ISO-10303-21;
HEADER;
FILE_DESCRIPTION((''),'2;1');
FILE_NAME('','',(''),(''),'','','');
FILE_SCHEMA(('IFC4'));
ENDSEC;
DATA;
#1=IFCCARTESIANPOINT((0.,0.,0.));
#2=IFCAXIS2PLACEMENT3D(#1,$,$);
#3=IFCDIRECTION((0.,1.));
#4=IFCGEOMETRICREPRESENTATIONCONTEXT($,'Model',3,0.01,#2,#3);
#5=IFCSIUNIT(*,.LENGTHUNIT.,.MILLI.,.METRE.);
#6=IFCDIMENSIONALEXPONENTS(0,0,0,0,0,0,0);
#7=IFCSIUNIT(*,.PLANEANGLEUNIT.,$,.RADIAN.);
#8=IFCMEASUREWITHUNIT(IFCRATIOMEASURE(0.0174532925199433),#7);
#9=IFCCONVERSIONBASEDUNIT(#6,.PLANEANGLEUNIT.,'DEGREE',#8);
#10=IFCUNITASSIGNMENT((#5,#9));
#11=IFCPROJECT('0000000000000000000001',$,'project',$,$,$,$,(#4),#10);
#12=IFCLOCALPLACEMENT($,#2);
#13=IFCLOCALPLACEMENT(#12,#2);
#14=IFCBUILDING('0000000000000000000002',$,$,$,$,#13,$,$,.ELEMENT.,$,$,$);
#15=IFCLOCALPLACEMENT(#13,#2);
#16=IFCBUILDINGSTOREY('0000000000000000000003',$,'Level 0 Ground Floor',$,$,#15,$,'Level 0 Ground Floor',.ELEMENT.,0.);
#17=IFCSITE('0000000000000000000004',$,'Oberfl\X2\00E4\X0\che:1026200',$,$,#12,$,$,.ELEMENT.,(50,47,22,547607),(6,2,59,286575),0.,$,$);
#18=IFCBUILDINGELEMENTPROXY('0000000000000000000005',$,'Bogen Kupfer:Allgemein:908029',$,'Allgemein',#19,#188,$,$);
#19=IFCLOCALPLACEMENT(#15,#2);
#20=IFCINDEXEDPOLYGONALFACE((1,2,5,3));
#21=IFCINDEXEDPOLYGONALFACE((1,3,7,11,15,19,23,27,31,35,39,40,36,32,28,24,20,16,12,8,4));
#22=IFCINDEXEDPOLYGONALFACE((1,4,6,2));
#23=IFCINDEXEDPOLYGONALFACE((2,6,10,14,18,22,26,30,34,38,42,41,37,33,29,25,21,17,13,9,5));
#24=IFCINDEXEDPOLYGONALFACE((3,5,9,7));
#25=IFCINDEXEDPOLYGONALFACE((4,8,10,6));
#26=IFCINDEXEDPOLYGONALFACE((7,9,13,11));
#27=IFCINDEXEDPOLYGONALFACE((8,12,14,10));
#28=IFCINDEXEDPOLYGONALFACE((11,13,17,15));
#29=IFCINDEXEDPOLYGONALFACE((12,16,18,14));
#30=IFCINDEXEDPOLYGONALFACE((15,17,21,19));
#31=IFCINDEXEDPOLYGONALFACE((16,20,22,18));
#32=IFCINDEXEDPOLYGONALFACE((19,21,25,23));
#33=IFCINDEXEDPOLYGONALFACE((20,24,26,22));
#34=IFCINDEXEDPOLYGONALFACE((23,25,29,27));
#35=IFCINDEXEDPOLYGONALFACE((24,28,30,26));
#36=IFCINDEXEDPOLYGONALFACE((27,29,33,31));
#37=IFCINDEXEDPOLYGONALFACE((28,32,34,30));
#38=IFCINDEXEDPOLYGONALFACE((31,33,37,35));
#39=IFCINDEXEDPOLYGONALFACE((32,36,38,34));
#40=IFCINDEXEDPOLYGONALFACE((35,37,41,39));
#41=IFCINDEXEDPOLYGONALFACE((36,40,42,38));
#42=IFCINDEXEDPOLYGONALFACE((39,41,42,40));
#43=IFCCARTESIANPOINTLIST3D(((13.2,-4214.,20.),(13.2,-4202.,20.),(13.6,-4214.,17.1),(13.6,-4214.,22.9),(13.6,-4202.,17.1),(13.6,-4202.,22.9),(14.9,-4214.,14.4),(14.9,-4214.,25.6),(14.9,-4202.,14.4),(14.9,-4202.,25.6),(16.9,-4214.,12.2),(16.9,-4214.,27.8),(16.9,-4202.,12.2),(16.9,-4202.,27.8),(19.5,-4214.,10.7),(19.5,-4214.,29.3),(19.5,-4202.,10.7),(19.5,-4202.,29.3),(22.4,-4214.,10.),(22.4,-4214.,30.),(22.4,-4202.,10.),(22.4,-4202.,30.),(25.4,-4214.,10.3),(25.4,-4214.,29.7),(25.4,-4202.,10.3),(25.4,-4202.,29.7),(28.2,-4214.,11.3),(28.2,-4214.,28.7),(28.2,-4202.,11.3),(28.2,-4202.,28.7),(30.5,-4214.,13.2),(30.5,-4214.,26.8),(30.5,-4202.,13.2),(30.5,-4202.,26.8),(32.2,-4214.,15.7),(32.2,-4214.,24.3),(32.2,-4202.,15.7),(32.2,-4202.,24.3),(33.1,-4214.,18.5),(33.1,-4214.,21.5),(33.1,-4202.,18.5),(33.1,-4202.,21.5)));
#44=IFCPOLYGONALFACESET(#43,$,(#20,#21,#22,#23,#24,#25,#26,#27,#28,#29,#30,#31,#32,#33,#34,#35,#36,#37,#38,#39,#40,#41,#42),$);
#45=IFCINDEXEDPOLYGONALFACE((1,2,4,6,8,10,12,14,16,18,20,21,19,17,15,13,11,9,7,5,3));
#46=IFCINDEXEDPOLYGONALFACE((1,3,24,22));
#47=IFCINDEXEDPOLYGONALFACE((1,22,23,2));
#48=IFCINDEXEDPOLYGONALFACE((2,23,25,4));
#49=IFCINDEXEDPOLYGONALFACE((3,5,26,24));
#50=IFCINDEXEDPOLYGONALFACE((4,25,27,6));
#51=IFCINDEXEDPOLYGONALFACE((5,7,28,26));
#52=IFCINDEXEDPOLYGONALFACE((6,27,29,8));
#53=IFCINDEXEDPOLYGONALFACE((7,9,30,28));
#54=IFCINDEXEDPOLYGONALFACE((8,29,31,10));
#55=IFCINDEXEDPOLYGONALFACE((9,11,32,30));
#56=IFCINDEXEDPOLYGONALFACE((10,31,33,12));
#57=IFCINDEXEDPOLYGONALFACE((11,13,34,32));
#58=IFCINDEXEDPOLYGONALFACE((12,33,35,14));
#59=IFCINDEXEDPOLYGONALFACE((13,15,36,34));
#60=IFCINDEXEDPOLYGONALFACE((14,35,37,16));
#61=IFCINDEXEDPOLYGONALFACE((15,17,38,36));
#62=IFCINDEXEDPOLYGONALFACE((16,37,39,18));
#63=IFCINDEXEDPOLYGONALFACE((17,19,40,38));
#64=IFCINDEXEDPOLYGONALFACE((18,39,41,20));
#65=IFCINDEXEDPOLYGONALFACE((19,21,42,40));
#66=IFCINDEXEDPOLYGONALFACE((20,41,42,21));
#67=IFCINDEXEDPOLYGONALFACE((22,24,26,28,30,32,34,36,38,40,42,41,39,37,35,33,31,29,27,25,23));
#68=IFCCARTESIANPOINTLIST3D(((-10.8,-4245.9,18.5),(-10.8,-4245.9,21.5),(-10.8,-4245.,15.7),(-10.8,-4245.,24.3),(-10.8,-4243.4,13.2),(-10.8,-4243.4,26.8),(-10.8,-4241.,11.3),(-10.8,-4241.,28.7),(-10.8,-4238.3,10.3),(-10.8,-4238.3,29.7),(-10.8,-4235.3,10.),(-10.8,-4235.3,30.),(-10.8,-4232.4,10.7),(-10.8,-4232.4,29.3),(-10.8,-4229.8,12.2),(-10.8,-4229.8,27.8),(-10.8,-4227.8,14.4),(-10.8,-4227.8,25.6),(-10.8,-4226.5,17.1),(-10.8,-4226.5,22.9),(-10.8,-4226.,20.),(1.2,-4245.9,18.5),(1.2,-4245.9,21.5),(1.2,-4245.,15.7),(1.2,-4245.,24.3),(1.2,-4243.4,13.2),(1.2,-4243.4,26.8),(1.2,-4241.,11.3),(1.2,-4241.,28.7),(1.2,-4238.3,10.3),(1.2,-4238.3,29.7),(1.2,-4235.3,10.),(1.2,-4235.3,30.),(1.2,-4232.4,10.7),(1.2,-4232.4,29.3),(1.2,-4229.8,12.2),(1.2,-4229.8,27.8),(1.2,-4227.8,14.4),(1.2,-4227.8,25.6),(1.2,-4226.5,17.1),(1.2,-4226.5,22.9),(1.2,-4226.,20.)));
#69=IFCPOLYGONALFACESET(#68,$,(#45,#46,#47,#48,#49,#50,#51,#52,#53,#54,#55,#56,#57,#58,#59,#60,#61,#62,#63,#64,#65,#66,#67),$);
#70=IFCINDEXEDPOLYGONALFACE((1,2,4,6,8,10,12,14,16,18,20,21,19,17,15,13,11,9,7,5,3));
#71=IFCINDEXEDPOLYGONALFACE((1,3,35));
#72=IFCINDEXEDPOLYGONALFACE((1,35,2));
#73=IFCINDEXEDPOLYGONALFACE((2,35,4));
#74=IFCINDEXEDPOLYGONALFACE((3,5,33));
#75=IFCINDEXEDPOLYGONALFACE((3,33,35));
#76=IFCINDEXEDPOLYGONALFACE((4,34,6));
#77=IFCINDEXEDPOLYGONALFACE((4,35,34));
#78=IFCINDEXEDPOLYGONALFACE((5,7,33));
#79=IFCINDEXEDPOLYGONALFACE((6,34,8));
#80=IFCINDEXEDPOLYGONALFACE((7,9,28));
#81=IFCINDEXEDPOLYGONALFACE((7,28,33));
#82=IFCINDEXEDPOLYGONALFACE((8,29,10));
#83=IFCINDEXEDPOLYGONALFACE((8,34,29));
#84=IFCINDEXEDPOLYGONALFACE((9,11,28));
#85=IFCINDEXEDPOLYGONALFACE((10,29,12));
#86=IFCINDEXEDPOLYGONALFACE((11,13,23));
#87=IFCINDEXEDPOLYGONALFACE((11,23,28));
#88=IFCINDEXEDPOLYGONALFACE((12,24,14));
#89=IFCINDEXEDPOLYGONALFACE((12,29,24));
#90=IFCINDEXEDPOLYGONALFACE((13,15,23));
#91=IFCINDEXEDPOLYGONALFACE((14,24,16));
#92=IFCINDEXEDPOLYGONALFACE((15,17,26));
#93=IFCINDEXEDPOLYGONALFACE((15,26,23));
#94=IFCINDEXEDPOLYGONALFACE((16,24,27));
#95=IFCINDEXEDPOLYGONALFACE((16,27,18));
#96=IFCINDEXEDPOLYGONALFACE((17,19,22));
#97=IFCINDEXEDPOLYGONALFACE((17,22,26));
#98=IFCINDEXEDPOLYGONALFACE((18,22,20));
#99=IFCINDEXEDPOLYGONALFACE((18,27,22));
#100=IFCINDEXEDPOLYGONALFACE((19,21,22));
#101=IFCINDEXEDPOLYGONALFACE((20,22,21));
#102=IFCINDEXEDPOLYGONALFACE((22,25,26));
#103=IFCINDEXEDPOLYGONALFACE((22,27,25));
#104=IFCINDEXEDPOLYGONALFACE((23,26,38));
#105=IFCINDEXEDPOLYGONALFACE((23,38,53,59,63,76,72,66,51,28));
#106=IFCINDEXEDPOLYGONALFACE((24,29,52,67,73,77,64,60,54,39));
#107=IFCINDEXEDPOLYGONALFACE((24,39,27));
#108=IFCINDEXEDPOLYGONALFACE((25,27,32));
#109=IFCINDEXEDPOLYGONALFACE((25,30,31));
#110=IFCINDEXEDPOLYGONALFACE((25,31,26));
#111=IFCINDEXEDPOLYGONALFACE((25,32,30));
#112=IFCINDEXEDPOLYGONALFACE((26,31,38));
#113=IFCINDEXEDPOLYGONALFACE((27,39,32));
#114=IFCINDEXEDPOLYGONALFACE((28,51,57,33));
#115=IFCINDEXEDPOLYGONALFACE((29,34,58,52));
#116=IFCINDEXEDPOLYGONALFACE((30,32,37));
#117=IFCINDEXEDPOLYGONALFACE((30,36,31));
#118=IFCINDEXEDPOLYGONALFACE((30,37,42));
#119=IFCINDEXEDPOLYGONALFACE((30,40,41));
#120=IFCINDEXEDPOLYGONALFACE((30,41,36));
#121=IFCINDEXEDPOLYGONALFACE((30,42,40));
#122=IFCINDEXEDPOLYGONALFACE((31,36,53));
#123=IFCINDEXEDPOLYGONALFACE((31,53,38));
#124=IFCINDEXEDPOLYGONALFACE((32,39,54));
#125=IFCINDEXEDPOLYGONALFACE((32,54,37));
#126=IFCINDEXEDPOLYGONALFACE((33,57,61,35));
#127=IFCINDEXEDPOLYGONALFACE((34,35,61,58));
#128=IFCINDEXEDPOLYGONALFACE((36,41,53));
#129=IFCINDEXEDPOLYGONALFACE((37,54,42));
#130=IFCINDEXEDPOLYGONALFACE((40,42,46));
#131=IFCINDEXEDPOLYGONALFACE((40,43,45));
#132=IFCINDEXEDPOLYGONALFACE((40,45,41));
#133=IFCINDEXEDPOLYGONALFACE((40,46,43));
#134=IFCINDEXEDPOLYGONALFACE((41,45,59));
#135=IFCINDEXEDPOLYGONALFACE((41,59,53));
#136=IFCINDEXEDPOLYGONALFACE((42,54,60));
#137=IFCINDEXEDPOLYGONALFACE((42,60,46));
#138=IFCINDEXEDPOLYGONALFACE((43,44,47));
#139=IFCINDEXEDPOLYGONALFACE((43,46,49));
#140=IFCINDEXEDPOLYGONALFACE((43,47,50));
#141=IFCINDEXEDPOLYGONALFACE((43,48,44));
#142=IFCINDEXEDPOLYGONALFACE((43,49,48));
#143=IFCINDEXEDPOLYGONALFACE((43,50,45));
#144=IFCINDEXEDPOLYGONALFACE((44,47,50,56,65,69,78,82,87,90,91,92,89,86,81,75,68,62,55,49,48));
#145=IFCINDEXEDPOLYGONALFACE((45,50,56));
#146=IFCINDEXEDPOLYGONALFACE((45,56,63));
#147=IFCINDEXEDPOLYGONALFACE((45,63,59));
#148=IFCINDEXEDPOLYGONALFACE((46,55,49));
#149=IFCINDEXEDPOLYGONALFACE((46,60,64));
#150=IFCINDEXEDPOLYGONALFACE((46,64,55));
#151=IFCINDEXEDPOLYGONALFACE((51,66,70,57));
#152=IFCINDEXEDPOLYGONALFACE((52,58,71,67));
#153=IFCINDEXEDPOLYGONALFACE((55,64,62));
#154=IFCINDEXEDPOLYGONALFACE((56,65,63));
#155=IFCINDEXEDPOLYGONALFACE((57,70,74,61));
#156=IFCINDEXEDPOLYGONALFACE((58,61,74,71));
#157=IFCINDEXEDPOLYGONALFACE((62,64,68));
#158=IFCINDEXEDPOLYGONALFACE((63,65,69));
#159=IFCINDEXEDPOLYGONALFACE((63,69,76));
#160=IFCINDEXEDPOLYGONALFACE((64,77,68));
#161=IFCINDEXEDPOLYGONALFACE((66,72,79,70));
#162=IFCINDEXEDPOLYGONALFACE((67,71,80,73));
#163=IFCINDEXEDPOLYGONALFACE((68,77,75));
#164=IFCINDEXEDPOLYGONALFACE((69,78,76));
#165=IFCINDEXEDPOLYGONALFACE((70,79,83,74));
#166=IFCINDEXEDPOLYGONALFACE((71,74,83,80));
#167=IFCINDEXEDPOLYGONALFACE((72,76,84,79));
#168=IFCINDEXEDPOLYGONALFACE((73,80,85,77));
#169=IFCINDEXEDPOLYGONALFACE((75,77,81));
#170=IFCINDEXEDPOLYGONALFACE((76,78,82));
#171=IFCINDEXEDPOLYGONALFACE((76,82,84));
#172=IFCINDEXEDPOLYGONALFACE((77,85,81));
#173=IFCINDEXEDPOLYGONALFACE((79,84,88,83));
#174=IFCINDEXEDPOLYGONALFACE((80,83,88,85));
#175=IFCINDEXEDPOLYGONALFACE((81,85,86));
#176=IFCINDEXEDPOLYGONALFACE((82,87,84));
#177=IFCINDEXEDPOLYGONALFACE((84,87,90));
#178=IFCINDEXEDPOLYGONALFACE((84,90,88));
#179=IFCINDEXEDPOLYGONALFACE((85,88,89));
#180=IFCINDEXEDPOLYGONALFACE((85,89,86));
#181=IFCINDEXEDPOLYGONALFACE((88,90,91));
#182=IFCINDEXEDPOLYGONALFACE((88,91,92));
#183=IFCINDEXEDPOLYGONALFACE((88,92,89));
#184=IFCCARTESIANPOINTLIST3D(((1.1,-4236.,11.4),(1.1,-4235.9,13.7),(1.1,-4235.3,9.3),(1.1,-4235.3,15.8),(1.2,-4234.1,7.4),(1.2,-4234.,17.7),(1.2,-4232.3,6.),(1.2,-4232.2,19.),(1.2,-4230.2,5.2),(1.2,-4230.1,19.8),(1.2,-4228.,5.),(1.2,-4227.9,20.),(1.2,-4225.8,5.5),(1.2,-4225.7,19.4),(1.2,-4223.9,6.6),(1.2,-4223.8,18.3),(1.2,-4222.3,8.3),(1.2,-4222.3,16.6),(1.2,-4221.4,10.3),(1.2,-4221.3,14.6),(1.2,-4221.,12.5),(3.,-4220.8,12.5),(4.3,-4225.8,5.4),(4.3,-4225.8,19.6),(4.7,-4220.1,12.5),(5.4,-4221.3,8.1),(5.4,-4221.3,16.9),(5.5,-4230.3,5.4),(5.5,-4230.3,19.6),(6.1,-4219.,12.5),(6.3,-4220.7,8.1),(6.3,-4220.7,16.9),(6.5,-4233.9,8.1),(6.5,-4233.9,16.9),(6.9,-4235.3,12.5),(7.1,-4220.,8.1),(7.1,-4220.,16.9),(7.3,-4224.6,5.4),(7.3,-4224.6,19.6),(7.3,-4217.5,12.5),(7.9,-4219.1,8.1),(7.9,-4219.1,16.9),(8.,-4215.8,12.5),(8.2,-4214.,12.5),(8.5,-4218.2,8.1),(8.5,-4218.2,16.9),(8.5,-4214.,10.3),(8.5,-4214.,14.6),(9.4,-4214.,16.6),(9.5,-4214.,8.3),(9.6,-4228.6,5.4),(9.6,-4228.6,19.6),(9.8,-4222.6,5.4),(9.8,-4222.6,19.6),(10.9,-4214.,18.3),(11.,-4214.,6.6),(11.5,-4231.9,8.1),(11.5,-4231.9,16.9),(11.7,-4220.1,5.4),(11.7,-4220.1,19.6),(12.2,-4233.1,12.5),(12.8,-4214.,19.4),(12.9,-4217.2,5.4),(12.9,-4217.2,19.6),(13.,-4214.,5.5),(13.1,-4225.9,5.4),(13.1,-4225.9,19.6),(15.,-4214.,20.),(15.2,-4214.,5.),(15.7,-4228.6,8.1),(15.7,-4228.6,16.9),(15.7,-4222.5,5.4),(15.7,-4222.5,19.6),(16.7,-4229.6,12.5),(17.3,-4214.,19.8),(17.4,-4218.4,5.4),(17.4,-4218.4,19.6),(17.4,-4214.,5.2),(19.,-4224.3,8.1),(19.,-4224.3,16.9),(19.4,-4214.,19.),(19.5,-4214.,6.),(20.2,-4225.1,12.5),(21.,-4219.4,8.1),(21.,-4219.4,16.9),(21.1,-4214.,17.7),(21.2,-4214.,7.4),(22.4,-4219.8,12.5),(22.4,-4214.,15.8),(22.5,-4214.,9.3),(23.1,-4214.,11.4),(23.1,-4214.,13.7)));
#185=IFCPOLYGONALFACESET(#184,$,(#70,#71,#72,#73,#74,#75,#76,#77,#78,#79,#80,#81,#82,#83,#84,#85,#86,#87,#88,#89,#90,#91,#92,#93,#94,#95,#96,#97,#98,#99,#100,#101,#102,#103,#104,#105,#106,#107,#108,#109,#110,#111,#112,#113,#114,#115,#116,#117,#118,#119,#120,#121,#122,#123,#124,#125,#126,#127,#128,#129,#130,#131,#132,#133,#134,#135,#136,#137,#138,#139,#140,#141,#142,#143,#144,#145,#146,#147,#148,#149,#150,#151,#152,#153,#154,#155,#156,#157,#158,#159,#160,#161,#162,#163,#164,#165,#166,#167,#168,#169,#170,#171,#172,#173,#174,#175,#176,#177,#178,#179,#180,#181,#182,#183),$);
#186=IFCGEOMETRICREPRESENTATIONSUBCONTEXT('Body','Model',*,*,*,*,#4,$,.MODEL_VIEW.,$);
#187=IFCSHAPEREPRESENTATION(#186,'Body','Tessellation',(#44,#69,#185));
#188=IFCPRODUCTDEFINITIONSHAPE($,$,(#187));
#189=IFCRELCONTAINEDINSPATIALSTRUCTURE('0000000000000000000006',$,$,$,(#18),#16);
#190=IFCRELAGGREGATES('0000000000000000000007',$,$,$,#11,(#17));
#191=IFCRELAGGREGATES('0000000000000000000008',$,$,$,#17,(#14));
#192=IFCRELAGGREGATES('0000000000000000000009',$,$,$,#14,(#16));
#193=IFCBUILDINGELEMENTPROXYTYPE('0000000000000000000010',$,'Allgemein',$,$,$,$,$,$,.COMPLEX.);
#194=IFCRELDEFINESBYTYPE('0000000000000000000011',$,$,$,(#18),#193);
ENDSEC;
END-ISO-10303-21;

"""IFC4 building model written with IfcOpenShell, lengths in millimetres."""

from ifc_helpers import new_model, entity, si_unit, converted_unit, direction, frame, frame_2d, origin, place, context, subcontext, project, spatial, circle, extrude, source, transform, mapped, type_object, type_shapes, element, save


model = new_model("IFC4")

# Units and contexts
model_context = context("Model", 3, precision=0.01, world=origin(), true_north=direction((0.0, 1.0)))
body_context = subcontext(model_context, "Body", "Model", "MODEL_VIEW")
ifc_project = project(units=[si_unit("LENGTHUNIT", "METRE", prefix="MILLI"), converted_unit("PLANEANGLEUNIT", "DEGREE", entity("IfcRatioMeasure", 0.0174532925199433), si_unit("PLANEANGLEUNIT", "RADIAN"), dimensions=[0, 0, 0, 0, 0, 0, 0])], contexts=[model_context])

# Site, building, storey
site_placement = place(None, origin())
site = spatial("IfcSite", under=ifc_project, at=site_placement, Name="Oberfläche:1026200", CompositionType="ELEMENT", RefLatitude=(50, 47, 22, 547607), RefLongitude=(6, 2, 59, 286575), RefElevation=0.0)
building_placement = place(site_placement, origin())
building = spatial("IfcBuilding", under=site, at=building_placement, CompositionType="ELEMENT")
storey_placement = place(building_placement, origin())
storey = spatial("IfcBuildingStorey", under=building, at=storey_placement, Name="Level 0 Ground Floor", LongName="Level 0 Ground Floor", CompositionType="ELEMENT", Elevation=0.0)

# Building element proxy
building_element_proxy_type = type_object("IfcBuildingElementProxyType", Name="Allgemein", PredefinedType="COMPLEX")
ifc_direction = entity("IfcDirection", [0.0, 0.0, -1.0])
trimmed_curve = entity("IfcTrimmedCurve", entity("IfcCircle", entity("IfcAxis2Placement2D", entity("IfcCartesianPoint", [-14.5, 0.0]), entity("IfcDirection", [0.0, 1.0])), 14.5), [entity("IfcParameterValue", 270.0)], [entity("IfcParameterValue", 0.0)], True, "PARAMETER")
shared_shape_1 = source(origin(), body_context, "Body", "SolidModel", [
    extrude(circle(Radius=10.0, at=frame_2d((0.0, 0.0), x_axis=(1.0, 0.0))), frame((0.0, 22.0, 0.0), z_axis=(0.0, 1.0, 0.0), x_axis=(-1.0, 0.0, 0.0)), (0.0, 0.0, 1.0), 12.0),
    extrude(circle(Radius=10.0, at=frame_2d((0.0, 0.0), x_axis=(1.0, 0.0))), frame((-34.0, 0.0, 0.0), z_axis=(1.0, 0.0, 0.0), x_axis=(0.0, 1.0, 0.0)), (0.0, 0.0, 1.0), 12.0),
    entity("IfcSurfaceCurveSweptAreaSolid", entity("IfcCircleProfileDef", "AREA", None, entity("IfcAxis2Placement2D", entity("IfcCartesianPoint", [0.0, 7.5]), entity("IfcDirection", [1.0, 0.0])), 7.5), entity("IfcAxis2Placement3D", entity("IfcCartesianPoint", [-7.5, 22.0, 0.0]), ifc_direction, entity("IfcDirection", [1.0, 0.0, 0.0])), trimmed_curve, 0.0, 90.0, entity("IfcSurfaceOfLinearExtrusion", entity("IfcArbitraryOpenProfileDef", "CURVE", None, trimmed_curve), entity("IfcAxis2Placement3D", entity("IfcCartesianPoint", [0.0, 0.0, -304.8])), ifc_direction, 1.0)),
])
type_shapes(building_element_proxy_type, [shared_shape_1])
proxy_1_placement = place(storey_placement, frame((23.2, -4236.0, 20.0)))
element("IfcBuildingElementProxy", 1, at=proxy_1_placement, inside=storey, type_object=building_element_proxy_type, Name="Bogen Kupfer:Allgemein:908029", ObjectType="Allgemein", context=body_context, shape_type="MappedRepresentation", body=[
    mapped(shared_shape_1, transform((0.0, 0.0, 0.0), scale=1.0)),
])

save(model, "model.ifc")
